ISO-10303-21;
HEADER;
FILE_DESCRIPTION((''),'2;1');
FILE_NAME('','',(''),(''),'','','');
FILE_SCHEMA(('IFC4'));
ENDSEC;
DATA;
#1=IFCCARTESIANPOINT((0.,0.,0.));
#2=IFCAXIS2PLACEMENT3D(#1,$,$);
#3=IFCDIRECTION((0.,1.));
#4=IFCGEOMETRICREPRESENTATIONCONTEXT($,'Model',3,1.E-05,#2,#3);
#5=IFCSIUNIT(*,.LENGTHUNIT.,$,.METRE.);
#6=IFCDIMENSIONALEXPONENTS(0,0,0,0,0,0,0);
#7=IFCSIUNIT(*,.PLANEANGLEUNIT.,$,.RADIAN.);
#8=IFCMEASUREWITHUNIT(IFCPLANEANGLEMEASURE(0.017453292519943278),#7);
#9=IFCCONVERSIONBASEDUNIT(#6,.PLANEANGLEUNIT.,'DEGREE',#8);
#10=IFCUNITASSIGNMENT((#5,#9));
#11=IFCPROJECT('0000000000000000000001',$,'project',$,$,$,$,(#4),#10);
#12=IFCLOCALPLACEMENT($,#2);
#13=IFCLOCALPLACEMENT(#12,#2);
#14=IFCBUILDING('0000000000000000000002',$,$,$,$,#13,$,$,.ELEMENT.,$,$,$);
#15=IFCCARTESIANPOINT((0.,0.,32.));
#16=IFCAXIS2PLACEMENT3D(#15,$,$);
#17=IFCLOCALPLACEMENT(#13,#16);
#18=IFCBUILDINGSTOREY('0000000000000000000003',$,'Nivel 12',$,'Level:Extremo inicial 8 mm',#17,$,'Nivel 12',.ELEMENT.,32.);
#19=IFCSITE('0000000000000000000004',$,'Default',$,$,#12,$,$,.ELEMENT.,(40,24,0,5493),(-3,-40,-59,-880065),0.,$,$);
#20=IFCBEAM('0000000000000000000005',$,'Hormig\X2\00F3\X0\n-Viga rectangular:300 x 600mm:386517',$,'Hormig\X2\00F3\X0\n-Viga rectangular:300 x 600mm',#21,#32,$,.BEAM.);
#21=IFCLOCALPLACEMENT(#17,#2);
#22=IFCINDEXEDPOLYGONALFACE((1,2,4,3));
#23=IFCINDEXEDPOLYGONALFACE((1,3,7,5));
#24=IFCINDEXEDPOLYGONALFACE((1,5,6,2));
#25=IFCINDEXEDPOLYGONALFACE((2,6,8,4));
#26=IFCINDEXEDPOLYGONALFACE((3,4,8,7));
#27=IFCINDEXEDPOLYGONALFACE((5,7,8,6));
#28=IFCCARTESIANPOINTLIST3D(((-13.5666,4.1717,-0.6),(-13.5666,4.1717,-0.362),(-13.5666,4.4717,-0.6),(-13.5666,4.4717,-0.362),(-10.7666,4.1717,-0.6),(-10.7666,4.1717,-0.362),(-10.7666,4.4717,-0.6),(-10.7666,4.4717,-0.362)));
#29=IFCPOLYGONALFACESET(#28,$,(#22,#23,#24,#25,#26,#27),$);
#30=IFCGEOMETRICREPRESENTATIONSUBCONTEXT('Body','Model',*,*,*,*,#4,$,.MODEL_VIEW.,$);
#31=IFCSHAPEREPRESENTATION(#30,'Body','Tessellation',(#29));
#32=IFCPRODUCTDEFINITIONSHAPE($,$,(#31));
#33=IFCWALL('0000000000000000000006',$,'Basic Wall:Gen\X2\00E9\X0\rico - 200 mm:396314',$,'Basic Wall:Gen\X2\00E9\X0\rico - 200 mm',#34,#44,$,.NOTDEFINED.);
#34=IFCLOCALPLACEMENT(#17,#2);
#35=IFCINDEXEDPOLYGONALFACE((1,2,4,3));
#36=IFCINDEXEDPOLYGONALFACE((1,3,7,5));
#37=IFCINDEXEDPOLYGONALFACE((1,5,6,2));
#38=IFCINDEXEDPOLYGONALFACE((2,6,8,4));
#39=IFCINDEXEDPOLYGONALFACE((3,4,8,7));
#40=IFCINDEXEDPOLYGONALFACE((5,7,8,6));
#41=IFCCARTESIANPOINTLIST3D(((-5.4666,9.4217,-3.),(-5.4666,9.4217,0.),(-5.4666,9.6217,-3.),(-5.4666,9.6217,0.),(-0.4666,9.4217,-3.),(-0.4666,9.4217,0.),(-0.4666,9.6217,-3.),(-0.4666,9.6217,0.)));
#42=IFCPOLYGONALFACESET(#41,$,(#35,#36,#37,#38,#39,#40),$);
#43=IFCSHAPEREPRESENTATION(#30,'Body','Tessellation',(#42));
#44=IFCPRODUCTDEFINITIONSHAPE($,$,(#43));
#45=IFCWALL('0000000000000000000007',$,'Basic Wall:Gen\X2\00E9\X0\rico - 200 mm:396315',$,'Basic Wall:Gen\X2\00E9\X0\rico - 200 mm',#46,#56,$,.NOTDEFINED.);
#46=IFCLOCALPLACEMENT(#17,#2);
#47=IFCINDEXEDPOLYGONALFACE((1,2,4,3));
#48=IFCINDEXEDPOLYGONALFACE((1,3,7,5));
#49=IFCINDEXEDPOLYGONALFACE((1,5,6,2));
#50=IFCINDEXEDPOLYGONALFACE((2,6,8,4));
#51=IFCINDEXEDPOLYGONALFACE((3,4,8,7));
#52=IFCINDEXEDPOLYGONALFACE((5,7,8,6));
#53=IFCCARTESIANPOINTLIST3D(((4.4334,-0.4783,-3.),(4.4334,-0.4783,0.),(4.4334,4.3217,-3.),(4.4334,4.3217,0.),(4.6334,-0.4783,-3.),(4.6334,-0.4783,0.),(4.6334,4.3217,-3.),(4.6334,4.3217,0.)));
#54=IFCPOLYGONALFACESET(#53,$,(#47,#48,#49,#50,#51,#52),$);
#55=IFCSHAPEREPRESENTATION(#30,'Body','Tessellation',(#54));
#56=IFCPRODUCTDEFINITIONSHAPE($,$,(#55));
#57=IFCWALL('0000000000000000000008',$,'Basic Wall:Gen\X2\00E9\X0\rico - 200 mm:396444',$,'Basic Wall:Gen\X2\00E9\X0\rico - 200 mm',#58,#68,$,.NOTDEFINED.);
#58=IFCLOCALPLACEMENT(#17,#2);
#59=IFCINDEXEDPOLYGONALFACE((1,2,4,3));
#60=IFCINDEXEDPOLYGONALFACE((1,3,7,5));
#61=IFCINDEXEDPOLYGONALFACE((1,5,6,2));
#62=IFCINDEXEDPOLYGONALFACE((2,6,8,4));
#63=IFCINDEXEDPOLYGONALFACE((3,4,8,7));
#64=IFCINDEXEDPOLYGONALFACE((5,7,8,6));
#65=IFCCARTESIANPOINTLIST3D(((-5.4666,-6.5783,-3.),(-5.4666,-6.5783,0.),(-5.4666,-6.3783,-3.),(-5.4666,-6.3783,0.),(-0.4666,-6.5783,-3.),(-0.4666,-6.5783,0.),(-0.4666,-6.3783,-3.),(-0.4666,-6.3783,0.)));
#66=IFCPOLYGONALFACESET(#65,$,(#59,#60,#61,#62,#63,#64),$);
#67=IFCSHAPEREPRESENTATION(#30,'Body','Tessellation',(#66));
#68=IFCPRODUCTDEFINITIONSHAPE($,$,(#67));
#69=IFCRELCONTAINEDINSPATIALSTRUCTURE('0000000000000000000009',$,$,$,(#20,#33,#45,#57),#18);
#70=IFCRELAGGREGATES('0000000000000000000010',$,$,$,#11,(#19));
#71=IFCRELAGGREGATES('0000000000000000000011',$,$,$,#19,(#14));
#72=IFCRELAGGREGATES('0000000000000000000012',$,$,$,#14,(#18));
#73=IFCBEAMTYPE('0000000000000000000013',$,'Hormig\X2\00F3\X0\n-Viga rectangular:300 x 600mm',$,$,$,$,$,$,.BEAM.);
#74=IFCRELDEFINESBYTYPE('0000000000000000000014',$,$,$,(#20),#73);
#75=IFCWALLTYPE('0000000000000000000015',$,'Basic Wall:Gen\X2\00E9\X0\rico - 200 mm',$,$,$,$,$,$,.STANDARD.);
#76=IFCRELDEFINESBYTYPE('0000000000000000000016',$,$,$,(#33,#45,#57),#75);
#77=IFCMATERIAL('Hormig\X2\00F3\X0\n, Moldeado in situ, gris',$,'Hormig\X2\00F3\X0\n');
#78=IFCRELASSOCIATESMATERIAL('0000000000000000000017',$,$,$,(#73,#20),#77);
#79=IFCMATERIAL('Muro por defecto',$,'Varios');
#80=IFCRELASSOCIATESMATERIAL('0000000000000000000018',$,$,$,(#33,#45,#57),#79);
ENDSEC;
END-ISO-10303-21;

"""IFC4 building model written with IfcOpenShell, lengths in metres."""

from ifc_helpers import new_model, entity, si_unit, converted_unit, direction, frame, origin, place, context, subcontext, project, spatial, indexed_curve, outline, extrude, source, transform, mapped, material, type_object, type_shapes, element, save


model = new_model("IFC4")

# Units and contexts
model_context = context("Model", 3, precision=1e-05, world=origin(), true_north=direction((0.0, 1.0)))
body_context = subcontext(model_context, "Body", "Model", "MODEL_VIEW")
ifc_project = project(units=[si_unit("LENGTHUNIT", "METRE"), converted_unit("PLANEANGLEUNIT", "DEGREE", entity("IfcPlaneAngleMeasure", 0.017453292519943278), si_unit("PLANEANGLEUNIT", "RADIAN"), dimensions=[0, 0, 0, 0, 0, 0, 0])], contexts=[model_context])

# Site, building, storey
site_placement = place(None, origin())
site = spatial("IfcSite", under=ifc_project, at=site_placement, Name="Default", CompositionType="ELEMENT", RefLatitude=(40, 24, 0, 5493), RefLongitude=(-3, -40, -59, -880065), RefElevation=0.0)
building_placement = place(site_placement, origin())
building = spatial("IfcBuilding", under=site, at=building_placement, CompositionType="ELEMENT")
storey_placement = place(building_placement, frame((0.0, 0.0, 32.0)))
storey = spatial("IfcBuildingStorey", under=building, at=storey_placement, Name="Nivel 12", ObjectType="Level:Extremo inicial 8 mm", LongName="Nivel 12", CompositionType="ELEMENT", Elevation=32.0)

# Shared definitions
ifc_material_1 = material(Name="Hormigón, Moldeado in situ, gris", Category="Hormigón")

# Beam
beam_type_1 = type_object("IfcBeamType", Name="Hormigón-Viga rectangular:300 x 600mm", PredefinedType="BEAM", material=ifc_material_1)
shared_shape_1 = source(origin(), body_context, "Body", "SweptSolid", [
    extrude(outline(indexed_curve([(-0.119, -0.15), (0.119, -0.15), (0.119, 0.15), (-0.119, 0.15), (-0.119, -0.15)], self_intersect=False)), frame((-10.7666, 4.3217, 31.519), z_axis=(-1.0, 0.0, 0.0), x_axis=(0.0, 0.0, -1.0)), (0.0, 0.0, 1.0), 2.8),
])
type_shapes(beam_type_1, [shared_shape_1])
beam_1_placement = place(storey_placement, frame((0.0, 0.0, -32.0)))
element("IfcBeam", 1, at=beam_1_placement, inside=storey, type_object=beam_type_1, material=ifc_material_1, Name="Hormigón-Viga rectangular:300 x 600mm:386517", ObjectType="Hormigón-Viga rectangular:300 x 600mm", PredefinedType="BEAM", context=body_context, shape_type="MappedRepresentation", body=[
    mapped(shared_shape_1, transform((0.0, 0.0, 0.0), scale=1.0)),
])

# Walls
ifc_material_2 = material(Name="Muro por defecto", Category="Varios")
wall_type = type_object("IfcWallType", Name="Basic Wall:Genérico - 200 mm", PredefinedType="STANDARD")
wall_1_placement = place(storey_placement, frame((-5.4666, 9.5217, -3.0)))
element("IfcWall", 2, at=wall_1_placement, inside=storey, type_object=wall_type, material=ifc_material_2, Name="Basic Wall:Genérico - 200 mm:396314", ObjectType="Basic Wall:Genérico - 200 mm", PredefinedType="NOTDEFINED", context=body_context, shape_type="SweptSolid", body=[
    extrude(outline(indexed_curve([(5.0, 0.1), (0.0, 0.1), (0.0, -0.1), (5.0, -0.1), (5.0, 0.1)], self_intersect=False)), origin(), (0.0, 0.0, 1.0), 3.0),
])
wall_2_placement = place(storey_placement, frame((4.5334, 4.3217, -3.0), z_axis=(0.0, 0.0, 1.0), x_axis=(0.0, -1.0, 0.0)))
element("IfcWall", 3, at=wall_2_placement, inside=storey, type_object=wall_type, material=ifc_material_2, Name="Basic Wall:Genérico - 200 mm:396315", ObjectType="Basic Wall:Genérico - 200 mm", PredefinedType="NOTDEFINED", context=body_context, shape_type="SweptSolid", body=[
    extrude(outline(indexed_curve([(4.8, 0.1), (0.0, 0.1), (0.0, -0.1), (4.8, -0.1), (4.8, 0.1)], self_intersect=False)), origin(), (0.0, 0.0, 1.0), 3.0),
])
wall_3_placement = place(storey_placement, frame((-5.4666, -6.4783, -3.0)))
element("IfcWall", 4, at=wall_3_placement, inside=storey, type_object=wall_type, material=ifc_material_2, Name="Basic Wall:Genérico - 200 mm:396444", ObjectType="Basic Wall:Genérico - 200 mm", PredefinedType="NOTDEFINED", context=body_context, shape_type="SweptSolid", body=[
    extrude(outline(indexed_curve([(5.0, 0.1), (0.0, 0.1), (0.0, -0.1), (5.0, -0.1), (5.0, 0.1)], self_intersect=False)), origin(), (0.0, 0.0, 1.0), 3.0),
])

save(model, "model.ifc")
